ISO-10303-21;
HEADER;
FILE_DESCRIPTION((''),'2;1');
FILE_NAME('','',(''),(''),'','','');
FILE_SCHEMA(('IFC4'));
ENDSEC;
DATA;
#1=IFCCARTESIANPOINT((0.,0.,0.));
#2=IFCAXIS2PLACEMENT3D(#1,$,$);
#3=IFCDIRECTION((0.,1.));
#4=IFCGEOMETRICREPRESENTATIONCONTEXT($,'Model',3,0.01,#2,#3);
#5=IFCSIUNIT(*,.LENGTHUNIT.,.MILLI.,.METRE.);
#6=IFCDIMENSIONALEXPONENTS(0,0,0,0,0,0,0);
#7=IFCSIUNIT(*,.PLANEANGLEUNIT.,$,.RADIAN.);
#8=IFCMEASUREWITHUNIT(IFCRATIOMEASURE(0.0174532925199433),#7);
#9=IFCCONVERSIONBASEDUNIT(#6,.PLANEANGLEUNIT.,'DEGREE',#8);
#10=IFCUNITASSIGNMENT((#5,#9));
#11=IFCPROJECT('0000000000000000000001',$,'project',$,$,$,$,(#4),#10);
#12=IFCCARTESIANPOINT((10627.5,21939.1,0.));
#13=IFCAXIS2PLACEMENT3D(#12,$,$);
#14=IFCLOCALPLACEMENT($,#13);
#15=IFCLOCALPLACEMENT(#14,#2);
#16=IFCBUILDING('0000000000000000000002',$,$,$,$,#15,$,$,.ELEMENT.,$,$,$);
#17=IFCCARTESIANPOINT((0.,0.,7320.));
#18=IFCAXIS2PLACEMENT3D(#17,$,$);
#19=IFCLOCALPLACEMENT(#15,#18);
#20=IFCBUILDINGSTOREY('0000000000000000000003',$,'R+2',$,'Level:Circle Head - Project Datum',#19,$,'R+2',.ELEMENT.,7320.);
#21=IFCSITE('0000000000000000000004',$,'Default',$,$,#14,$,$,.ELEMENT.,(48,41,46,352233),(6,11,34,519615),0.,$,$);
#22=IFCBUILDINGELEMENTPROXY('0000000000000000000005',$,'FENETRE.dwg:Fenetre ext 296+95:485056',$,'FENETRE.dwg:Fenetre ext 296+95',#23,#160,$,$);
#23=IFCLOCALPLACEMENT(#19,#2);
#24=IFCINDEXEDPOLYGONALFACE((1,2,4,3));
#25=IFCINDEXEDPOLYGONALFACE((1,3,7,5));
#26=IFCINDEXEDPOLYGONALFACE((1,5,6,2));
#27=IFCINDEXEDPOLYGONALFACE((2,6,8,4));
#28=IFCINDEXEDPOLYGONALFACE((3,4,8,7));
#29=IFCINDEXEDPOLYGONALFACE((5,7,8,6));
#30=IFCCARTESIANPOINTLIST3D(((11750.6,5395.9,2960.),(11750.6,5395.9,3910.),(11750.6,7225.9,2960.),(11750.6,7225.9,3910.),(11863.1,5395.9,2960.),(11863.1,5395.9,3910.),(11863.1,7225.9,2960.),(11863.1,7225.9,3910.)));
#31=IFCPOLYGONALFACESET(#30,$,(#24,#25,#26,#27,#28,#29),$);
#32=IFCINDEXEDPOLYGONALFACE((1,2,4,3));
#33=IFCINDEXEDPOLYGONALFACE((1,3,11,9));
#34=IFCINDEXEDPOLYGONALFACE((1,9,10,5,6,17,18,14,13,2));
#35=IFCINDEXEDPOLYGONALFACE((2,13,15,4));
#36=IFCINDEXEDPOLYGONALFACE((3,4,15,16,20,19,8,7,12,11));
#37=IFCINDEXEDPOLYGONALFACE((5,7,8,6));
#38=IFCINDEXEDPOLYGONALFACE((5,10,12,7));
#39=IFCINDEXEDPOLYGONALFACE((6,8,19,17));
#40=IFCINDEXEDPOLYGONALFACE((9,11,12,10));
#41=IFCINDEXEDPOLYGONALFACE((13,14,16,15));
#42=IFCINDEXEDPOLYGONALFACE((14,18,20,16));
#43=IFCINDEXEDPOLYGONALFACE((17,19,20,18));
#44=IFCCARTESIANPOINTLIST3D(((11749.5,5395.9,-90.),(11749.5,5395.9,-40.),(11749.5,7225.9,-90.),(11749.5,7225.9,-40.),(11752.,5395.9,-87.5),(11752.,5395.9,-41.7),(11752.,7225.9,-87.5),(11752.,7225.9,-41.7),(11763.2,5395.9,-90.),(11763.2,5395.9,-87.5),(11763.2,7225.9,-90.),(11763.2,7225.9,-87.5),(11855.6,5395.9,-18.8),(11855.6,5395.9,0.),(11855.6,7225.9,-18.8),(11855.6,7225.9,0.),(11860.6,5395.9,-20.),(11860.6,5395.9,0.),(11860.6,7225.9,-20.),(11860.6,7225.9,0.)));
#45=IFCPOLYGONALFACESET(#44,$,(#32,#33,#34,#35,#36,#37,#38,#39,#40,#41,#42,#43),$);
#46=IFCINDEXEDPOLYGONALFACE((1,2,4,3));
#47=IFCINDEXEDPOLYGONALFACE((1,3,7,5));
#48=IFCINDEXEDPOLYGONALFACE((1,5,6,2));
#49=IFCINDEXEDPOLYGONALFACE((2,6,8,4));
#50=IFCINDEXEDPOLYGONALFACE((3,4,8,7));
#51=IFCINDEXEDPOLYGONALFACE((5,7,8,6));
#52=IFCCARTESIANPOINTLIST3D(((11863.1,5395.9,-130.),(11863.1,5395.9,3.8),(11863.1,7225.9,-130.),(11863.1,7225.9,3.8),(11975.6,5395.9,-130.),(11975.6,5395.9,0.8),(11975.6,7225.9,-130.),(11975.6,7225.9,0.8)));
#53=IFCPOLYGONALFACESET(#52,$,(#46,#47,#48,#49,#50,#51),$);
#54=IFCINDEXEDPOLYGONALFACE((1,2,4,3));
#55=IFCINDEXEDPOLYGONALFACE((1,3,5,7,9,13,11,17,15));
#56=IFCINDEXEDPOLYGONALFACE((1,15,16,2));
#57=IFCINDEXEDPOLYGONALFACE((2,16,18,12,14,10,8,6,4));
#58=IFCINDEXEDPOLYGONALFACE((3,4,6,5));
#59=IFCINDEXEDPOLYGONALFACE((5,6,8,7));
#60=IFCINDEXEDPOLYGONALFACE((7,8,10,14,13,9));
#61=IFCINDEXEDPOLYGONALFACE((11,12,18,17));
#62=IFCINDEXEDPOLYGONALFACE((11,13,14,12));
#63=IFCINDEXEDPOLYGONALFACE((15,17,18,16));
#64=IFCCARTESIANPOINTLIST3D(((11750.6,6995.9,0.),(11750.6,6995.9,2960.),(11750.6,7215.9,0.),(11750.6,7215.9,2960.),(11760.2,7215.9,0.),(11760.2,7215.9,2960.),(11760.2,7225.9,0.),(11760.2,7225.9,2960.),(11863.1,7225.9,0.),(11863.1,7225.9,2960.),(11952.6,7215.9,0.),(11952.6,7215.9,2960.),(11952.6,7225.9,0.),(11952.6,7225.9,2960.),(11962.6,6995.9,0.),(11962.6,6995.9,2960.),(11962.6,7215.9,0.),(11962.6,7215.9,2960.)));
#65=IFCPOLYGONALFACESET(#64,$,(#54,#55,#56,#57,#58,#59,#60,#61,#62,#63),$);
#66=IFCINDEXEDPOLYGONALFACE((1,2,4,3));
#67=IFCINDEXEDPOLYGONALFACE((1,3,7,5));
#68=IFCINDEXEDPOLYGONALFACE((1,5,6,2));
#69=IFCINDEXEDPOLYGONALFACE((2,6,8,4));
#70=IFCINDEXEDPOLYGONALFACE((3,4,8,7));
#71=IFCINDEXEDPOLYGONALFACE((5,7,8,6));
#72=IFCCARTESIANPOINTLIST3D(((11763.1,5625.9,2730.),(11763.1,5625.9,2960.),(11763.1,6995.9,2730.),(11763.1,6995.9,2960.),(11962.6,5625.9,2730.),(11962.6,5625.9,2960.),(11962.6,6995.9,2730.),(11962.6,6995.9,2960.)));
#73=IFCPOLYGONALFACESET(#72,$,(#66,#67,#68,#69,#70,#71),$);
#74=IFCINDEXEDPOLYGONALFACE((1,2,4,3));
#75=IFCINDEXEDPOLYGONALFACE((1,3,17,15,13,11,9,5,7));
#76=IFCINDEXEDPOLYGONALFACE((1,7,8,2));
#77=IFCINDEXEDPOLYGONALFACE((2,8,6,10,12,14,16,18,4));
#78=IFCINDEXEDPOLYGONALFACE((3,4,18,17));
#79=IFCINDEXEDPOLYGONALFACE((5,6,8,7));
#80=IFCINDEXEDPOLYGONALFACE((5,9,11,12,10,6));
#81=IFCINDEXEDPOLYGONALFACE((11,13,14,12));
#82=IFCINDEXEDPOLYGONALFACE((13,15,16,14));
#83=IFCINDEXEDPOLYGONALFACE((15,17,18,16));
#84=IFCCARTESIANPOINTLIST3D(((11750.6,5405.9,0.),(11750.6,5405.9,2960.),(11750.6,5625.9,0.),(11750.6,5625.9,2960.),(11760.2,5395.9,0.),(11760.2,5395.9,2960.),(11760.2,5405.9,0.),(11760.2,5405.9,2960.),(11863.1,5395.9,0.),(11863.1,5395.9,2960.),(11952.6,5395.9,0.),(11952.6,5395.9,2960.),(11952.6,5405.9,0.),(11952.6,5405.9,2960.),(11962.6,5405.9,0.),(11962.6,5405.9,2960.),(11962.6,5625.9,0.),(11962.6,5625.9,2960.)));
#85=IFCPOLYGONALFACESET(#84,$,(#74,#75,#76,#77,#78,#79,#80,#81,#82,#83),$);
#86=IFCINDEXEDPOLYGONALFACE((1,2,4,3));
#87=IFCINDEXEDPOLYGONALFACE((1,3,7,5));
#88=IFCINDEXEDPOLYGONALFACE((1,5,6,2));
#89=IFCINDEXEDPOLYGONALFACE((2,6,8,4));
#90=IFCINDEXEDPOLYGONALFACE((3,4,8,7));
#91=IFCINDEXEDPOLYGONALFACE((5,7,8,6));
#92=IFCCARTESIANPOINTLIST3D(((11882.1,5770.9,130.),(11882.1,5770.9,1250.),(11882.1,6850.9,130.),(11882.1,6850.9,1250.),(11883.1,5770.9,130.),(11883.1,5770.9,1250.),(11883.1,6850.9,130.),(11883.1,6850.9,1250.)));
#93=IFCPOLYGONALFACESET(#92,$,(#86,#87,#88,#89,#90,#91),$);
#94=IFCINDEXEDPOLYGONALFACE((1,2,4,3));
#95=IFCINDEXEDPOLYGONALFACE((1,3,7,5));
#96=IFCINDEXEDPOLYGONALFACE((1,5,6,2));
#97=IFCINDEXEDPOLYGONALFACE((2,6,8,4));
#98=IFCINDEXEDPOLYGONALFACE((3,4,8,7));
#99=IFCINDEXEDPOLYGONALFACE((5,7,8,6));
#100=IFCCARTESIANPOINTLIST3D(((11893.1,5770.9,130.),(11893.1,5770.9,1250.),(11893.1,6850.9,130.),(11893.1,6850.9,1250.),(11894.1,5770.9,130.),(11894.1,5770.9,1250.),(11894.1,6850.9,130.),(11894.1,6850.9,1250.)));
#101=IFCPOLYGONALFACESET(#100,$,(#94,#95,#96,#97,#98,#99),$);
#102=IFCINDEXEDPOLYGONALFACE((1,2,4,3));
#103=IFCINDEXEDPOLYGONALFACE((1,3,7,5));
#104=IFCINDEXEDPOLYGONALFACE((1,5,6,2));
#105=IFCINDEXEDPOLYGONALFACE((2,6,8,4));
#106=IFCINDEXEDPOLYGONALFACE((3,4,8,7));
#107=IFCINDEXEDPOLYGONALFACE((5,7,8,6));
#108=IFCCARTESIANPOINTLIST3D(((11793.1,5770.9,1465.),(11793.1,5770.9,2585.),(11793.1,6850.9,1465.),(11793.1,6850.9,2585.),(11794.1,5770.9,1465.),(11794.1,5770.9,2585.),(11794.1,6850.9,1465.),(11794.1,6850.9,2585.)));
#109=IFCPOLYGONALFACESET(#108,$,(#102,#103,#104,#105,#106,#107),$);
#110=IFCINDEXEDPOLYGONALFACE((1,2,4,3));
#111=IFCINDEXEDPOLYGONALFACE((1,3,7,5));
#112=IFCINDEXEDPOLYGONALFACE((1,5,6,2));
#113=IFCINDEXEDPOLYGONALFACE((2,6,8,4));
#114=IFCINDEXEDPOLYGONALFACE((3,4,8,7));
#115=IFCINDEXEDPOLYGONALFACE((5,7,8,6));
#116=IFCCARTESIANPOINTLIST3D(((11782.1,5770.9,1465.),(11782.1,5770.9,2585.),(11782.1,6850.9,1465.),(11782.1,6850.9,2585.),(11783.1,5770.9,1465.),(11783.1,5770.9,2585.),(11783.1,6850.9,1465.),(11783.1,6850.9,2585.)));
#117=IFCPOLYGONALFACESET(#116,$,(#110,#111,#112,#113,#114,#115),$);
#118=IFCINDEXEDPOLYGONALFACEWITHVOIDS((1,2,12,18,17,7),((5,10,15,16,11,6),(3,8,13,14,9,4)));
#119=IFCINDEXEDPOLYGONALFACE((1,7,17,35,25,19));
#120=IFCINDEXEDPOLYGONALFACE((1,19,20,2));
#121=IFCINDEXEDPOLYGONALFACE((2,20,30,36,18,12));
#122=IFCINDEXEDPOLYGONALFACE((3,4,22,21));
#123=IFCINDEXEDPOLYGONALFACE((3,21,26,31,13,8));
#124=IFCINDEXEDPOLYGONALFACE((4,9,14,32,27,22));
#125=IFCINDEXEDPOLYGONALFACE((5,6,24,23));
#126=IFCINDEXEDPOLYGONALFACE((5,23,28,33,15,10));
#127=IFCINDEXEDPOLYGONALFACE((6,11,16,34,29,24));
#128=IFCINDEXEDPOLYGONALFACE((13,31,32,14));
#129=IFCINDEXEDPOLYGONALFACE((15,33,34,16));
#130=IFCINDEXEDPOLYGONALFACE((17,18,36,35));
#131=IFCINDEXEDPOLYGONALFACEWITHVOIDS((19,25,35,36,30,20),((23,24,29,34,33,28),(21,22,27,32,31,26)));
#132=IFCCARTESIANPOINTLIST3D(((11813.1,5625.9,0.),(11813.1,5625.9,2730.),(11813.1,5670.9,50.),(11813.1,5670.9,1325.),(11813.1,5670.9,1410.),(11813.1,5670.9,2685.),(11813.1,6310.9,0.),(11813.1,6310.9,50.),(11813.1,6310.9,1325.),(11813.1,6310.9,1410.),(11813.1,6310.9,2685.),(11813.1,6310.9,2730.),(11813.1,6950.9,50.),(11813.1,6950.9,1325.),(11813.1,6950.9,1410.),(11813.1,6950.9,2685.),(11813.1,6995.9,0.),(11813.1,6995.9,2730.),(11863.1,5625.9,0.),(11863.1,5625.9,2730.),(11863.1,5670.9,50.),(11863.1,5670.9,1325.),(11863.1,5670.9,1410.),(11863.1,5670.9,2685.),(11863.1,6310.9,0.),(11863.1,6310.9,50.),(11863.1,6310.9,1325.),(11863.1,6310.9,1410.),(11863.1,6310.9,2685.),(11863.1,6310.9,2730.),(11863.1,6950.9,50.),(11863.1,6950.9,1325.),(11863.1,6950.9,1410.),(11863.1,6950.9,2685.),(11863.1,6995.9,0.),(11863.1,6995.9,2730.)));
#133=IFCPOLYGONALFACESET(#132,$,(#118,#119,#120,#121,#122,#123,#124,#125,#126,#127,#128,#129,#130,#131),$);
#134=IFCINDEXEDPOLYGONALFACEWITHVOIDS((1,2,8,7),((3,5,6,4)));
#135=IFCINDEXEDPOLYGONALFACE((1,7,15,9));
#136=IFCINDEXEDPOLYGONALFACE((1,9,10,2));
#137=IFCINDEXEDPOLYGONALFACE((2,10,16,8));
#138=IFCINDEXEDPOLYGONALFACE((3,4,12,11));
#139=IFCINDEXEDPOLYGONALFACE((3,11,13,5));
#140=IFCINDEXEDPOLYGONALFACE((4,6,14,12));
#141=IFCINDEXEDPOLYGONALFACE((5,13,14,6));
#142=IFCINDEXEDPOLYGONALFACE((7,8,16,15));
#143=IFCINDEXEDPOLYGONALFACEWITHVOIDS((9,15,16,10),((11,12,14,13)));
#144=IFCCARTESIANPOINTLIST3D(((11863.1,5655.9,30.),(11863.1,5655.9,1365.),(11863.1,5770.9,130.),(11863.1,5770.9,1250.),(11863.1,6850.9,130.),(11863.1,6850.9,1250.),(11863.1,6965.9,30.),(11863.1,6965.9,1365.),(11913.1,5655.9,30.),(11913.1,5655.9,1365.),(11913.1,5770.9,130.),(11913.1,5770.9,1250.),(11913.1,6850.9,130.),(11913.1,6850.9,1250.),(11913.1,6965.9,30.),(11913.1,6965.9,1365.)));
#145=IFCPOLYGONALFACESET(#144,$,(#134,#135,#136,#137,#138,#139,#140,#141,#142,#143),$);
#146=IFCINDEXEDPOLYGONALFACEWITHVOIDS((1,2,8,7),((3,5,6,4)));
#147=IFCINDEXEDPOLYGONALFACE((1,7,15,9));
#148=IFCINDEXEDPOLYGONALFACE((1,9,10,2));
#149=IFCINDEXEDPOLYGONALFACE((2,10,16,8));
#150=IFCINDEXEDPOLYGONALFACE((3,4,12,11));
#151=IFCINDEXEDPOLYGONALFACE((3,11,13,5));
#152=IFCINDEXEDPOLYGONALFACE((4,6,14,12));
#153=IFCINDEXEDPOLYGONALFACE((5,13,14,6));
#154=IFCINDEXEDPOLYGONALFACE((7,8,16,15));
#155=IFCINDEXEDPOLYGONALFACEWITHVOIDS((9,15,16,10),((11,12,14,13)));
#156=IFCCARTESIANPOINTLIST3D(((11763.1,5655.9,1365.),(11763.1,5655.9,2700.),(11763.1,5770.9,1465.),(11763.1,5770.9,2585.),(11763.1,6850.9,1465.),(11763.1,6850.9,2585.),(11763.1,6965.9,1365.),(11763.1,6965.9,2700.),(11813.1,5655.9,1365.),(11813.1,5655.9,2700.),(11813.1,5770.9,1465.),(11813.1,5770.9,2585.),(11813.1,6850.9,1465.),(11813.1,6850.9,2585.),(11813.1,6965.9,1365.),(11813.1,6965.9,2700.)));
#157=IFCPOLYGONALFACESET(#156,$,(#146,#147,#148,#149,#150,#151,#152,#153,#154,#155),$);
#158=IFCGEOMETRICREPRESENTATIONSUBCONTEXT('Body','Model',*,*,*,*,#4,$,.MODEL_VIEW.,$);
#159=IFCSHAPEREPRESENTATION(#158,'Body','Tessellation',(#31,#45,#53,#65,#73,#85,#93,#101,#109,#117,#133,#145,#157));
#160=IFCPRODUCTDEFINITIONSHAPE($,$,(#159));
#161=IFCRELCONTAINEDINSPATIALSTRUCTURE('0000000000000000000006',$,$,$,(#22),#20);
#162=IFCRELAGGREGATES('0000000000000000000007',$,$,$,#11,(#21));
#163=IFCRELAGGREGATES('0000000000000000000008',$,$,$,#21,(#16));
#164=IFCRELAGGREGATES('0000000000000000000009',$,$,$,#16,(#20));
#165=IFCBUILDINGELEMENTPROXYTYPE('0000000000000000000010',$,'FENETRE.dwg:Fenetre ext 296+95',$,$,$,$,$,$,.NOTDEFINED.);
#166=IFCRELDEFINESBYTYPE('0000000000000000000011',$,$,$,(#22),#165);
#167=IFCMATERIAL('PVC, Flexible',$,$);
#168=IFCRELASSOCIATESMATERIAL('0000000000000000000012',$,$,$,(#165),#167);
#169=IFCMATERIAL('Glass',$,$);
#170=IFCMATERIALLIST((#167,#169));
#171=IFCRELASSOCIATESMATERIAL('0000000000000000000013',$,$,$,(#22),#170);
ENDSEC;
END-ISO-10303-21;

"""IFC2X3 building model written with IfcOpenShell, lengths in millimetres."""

from ifc_helpers import new_model, entity, si_unit, converted_unit, direction, frame, frame_2d, origin, origin_2d_with_axis, place, context, subcontext, project, spatial, polyline, rectangle, outline, extrude, source, transform, mapped, material, material_list, type_object, type_shapes, element, save


model = new_model("IFC2X3")

# Units and contexts
model_context = context("Model", 3, precision=0.01, world=origin(), true_north=direction((0.0, 1.0)))
body_context = subcontext(model_context, "Body", "Model", "MODEL_VIEW")
ifc_project = project(units=[si_unit("LENGTHUNIT", "METRE", prefix="MILLI"), converted_unit("PLANEANGLEUNIT", "DEGREE", entity("IfcRatioMeasure", 0.0174532925199433), si_unit("PLANEANGLEUNIT", "RADIAN"), dimensions=[0, 0, 0, 0, 0, 0, 0])], contexts=[model_context])

# Site, building, storey
site_placement = place(None, frame((10627.5, 21939.1, 0.0)))
site = spatial("IfcSite", under=ifc_project, at=site_placement, Name="Default", CompositionType="ELEMENT", RefLatitude=(48, 41, 46, 352233), RefLongitude=(6, 11, 34, 519615), RefElevation=0.0)
building_placement = place(site_placement, origin())
building = spatial("IfcBuilding", under=site, at=building_placement, CompositionType="ELEMENT")
storey_placement = place(building_placement, frame((0.0, 0.0, 7320.0)))
storey = spatial("IfcBuildingStorey", under=building, at=storey_placement, Name="R+2", ObjectType="Level:Circle Head - Project Datum", LongName="R+2", CompositionType="ELEMENT", Elevation=7320.0)

# Building element proxy
ifc_material_1 = material(Name="PVC, Flexible")
ifc_material_2 = material(Name="Glass")
ifc_material_list_1 = material_list([ifc_material_1, ifc_material_2])
building_element_proxy_type_1 = type_object("IfcBuildingElementProxyType", Name="FENETRE.dwg:Fenetre ext 296+95", PredefinedType="NOTDEFINED", material=ifc_material_1)
shared_shape_1 = source(origin(), body_context, "Body", "SweptSolid", [
    extrude(rectangle(XDim=1830.0, YDim=112.5, at=origin_2d_with_axis()), frame((-10.4, 56.3, 2960.0), z_axis=(0.0, 0.0, 1.0), x_axis=(-1.0, 0.0, 0.0)), (0.0, 0.0, 1.0), 950.0),
    extrude(outline(polyline([(-68.6, -14.4), (-72.5, -34.0), (-67.6, -35.0), (-63.9, -16.6), (44.3, -16.6), (54.1, 32.5), (40.6, 35.2), (40.1, 32.7), (51.2, 30.5), (42.2, -14.4), (-68.6, -14.4)])), frame((-925.4, 66.9, -47.5), z_axis=(-1.0, 0.0, 0.0), x_axis=(0.0, 0.980599, -0.196027)), (0.0, 0.0, -1.0), 1830.0),
    extrude(outline(polyline([(-64.7, -56.3), (66.2, -56.3), (66.2, 56.3), (-67.7, 56.3), (-64.7, -56.3)])), frame((-925.4, -56.3, -63.8), z_axis=(1.0, 0.0, 0.0), x_axis=(0.0, 0.0, -1.0)), (0.0, 0.0, 1.0), 1830.0),
    extrude(outline(polyline([(-55.6, 97.0), (-55.6, -5.9), (-55.6, -95.4), (-45.6, -95.4), (-45.6, -105.4), (174.4, -105.4), (174.4, 106.6), (-45.6, 106.6), (-45.6, 97.0), (-55.6, 97.0)])), frame((849.0, 5.9, 0.0), z_axis=(0.0, 0.0, -1.0), x_axis=(-1.0, 0.0, 0.0)), (0.0, 0.0, -1.0), 2960.0),
    extrude(rectangle(XDim=199.5, YDim=1370.0, at=origin_2d_with_axis()), frame((-10.4, 0.3, 2730.0), z_axis=(0.0, 0.0, 1.0), x_axis=(0.0, 1.0, 0.0)), (0.0, 0.0, 1.0), 230.0),
    extrude(outline(polyline([(-97.0, -55.6), (5.9, -55.6), (95.4, -55.6), (95.4, -45.6), (105.4, -45.6), (105.4, 174.4), (-106.6, 174.4), (-106.6, -45.6), (-97.0, -45.6), (-97.0, -55.6)])), frame((-869.9, 5.9, 0.0), z_axis=(0.0, 0.0, 1.0), x_axis=(0.0, -1.0, 0.0)), (0.0, 0.0, 1.0), 2960.0),
    extrude(rectangle(XDim=1.0, YDim=1080.0, at=origin_2d_with_axis()), frame((-10.4, -19.5, 130.0), z_axis=(0.0, 0.0, 1.0), x_axis=(0.0, 1.0, 0.0)), (0.0, 0.0, 1.0), 1120.0),
    extrude(rectangle(XDim=1.0, YDim=1080.0, at=frame_2d((0.0, 0.0), x_axis=(1.0, 0.0))), frame((-10.4, -30.5, 130.0), z_axis=(0.0, 0.0, 1.0), x_axis=(0.0, 1.0, 0.0)), (0.0, 0.0, 1.0), 1120.0),
    extrude(rectangle(XDim=1.0, YDim=1080.0, at=frame_2d((0.0, 0.0), x_axis=(1.0, 0.0))), frame((-10.4, 69.5, 1465.0), z_axis=(0.0, 0.0, 1.0), x_axis=(0.0, 1.0, 0.0)), (0.0, 0.0, 1.0), 1120.0),
    extrude(rectangle(XDim=1.0, YDim=1080.0, at=frame_2d((0.0, 0.0), x_axis=(1.0, 0.0))), frame((-10.4, 80.5, 1465.0), z_axis=(0.0, 0.0, 1.0), x_axis=(0.0, 1.0, 0.0)), (0.0, 0.0, 1.0), 1120.0),
    extrude(outline(polyline([(-685.0, -1365.0), (0.0, -1365.0), (685.0, -1365.0), (685.0, 1365.0), (0.0, 1365.0), (-685.0, 1365.0), (-685.0, -1365.0)]), holes=[polyline([(-640.0, -1320.0), (-640.0, -45.0), (0.0, -45.0), (640.0, -45.0), (640.0, -1320.0), (0.0, -1320.0), (-640.0, -1320.0)]), polyline([(-640.0, 40.0), (-640.0, 1315.0), (0.0, 1315.0), (640.0, 1315.0), (640.0, 40.0), (0.0, 40.0), (-640.0, 40.0)])]), frame((-10.4, 0.0, 1365.0), z_axis=(0.0, 1.0, 0.0), x_axis=(1.0, 0.0, 0.0)), (0.0, 0.0, 1.0), 50.0),
    extrude(outline(polyline([(-655.0, -667.5), (655.0, -667.5), (655.0, 667.5), (-655.0, 667.5), (-655.0, -667.5)]), holes=[polyline([(-540.0, 552.5), (540.0, 552.5), (540.0, -567.5), (-540.0, -567.5), (-540.0, 552.5)])]), frame((-10.4, -50.0, 697.5), z_axis=(0.0, 1.0, 0.0), x_axis=(-1.0, 0.0, 0.0)), (0.0, 0.0, 1.0), 50.0),
    extrude(outline(polyline([(-655.0, -667.5), (655.0, -667.5), (655.0, 667.5), (-655.0, 667.5), (-655.0, -667.5)]), holes=[polyline([(-540.0, 552.5), (540.0, 552.5), (540.0, -567.5), (-540.0, -567.5), (-540.0, 552.5)])]), frame((-10.4, 50.0, 2032.5), z_axis=(0.0, 1.0, 0.0), x_axis=(-1.0, 0.0, 0.0)), (0.0, 0.0, 1.0), 50.0),
])
type_shapes(building_element_proxy_type_1, [shared_shape_1])
proxy_1_placement = place(storey_placement, frame((11863.1, 6321.3, 0.0), z_axis=(0.0, 0.0, 1.0), x_axis=(0.0, 1.0, 0.0)))
element("IfcBuildingElementProxy", 1, at=proxy_1_placement, inside=storey, type_object=building_element_proxy_type_1, material=ifc_material_list_1, Name="FENETRE.dwg:Fenetre ext 296+95:485056", ObjectType="FENETRE.dwg:Fenetre ext 296+95", context=body_context, shape_type="MappedRepresentation", body=[
    mapped(shared_shape_1, transform((0.0, 0.0, 0.0), scale=1.0)),
])

save(model, "model.ifc")
